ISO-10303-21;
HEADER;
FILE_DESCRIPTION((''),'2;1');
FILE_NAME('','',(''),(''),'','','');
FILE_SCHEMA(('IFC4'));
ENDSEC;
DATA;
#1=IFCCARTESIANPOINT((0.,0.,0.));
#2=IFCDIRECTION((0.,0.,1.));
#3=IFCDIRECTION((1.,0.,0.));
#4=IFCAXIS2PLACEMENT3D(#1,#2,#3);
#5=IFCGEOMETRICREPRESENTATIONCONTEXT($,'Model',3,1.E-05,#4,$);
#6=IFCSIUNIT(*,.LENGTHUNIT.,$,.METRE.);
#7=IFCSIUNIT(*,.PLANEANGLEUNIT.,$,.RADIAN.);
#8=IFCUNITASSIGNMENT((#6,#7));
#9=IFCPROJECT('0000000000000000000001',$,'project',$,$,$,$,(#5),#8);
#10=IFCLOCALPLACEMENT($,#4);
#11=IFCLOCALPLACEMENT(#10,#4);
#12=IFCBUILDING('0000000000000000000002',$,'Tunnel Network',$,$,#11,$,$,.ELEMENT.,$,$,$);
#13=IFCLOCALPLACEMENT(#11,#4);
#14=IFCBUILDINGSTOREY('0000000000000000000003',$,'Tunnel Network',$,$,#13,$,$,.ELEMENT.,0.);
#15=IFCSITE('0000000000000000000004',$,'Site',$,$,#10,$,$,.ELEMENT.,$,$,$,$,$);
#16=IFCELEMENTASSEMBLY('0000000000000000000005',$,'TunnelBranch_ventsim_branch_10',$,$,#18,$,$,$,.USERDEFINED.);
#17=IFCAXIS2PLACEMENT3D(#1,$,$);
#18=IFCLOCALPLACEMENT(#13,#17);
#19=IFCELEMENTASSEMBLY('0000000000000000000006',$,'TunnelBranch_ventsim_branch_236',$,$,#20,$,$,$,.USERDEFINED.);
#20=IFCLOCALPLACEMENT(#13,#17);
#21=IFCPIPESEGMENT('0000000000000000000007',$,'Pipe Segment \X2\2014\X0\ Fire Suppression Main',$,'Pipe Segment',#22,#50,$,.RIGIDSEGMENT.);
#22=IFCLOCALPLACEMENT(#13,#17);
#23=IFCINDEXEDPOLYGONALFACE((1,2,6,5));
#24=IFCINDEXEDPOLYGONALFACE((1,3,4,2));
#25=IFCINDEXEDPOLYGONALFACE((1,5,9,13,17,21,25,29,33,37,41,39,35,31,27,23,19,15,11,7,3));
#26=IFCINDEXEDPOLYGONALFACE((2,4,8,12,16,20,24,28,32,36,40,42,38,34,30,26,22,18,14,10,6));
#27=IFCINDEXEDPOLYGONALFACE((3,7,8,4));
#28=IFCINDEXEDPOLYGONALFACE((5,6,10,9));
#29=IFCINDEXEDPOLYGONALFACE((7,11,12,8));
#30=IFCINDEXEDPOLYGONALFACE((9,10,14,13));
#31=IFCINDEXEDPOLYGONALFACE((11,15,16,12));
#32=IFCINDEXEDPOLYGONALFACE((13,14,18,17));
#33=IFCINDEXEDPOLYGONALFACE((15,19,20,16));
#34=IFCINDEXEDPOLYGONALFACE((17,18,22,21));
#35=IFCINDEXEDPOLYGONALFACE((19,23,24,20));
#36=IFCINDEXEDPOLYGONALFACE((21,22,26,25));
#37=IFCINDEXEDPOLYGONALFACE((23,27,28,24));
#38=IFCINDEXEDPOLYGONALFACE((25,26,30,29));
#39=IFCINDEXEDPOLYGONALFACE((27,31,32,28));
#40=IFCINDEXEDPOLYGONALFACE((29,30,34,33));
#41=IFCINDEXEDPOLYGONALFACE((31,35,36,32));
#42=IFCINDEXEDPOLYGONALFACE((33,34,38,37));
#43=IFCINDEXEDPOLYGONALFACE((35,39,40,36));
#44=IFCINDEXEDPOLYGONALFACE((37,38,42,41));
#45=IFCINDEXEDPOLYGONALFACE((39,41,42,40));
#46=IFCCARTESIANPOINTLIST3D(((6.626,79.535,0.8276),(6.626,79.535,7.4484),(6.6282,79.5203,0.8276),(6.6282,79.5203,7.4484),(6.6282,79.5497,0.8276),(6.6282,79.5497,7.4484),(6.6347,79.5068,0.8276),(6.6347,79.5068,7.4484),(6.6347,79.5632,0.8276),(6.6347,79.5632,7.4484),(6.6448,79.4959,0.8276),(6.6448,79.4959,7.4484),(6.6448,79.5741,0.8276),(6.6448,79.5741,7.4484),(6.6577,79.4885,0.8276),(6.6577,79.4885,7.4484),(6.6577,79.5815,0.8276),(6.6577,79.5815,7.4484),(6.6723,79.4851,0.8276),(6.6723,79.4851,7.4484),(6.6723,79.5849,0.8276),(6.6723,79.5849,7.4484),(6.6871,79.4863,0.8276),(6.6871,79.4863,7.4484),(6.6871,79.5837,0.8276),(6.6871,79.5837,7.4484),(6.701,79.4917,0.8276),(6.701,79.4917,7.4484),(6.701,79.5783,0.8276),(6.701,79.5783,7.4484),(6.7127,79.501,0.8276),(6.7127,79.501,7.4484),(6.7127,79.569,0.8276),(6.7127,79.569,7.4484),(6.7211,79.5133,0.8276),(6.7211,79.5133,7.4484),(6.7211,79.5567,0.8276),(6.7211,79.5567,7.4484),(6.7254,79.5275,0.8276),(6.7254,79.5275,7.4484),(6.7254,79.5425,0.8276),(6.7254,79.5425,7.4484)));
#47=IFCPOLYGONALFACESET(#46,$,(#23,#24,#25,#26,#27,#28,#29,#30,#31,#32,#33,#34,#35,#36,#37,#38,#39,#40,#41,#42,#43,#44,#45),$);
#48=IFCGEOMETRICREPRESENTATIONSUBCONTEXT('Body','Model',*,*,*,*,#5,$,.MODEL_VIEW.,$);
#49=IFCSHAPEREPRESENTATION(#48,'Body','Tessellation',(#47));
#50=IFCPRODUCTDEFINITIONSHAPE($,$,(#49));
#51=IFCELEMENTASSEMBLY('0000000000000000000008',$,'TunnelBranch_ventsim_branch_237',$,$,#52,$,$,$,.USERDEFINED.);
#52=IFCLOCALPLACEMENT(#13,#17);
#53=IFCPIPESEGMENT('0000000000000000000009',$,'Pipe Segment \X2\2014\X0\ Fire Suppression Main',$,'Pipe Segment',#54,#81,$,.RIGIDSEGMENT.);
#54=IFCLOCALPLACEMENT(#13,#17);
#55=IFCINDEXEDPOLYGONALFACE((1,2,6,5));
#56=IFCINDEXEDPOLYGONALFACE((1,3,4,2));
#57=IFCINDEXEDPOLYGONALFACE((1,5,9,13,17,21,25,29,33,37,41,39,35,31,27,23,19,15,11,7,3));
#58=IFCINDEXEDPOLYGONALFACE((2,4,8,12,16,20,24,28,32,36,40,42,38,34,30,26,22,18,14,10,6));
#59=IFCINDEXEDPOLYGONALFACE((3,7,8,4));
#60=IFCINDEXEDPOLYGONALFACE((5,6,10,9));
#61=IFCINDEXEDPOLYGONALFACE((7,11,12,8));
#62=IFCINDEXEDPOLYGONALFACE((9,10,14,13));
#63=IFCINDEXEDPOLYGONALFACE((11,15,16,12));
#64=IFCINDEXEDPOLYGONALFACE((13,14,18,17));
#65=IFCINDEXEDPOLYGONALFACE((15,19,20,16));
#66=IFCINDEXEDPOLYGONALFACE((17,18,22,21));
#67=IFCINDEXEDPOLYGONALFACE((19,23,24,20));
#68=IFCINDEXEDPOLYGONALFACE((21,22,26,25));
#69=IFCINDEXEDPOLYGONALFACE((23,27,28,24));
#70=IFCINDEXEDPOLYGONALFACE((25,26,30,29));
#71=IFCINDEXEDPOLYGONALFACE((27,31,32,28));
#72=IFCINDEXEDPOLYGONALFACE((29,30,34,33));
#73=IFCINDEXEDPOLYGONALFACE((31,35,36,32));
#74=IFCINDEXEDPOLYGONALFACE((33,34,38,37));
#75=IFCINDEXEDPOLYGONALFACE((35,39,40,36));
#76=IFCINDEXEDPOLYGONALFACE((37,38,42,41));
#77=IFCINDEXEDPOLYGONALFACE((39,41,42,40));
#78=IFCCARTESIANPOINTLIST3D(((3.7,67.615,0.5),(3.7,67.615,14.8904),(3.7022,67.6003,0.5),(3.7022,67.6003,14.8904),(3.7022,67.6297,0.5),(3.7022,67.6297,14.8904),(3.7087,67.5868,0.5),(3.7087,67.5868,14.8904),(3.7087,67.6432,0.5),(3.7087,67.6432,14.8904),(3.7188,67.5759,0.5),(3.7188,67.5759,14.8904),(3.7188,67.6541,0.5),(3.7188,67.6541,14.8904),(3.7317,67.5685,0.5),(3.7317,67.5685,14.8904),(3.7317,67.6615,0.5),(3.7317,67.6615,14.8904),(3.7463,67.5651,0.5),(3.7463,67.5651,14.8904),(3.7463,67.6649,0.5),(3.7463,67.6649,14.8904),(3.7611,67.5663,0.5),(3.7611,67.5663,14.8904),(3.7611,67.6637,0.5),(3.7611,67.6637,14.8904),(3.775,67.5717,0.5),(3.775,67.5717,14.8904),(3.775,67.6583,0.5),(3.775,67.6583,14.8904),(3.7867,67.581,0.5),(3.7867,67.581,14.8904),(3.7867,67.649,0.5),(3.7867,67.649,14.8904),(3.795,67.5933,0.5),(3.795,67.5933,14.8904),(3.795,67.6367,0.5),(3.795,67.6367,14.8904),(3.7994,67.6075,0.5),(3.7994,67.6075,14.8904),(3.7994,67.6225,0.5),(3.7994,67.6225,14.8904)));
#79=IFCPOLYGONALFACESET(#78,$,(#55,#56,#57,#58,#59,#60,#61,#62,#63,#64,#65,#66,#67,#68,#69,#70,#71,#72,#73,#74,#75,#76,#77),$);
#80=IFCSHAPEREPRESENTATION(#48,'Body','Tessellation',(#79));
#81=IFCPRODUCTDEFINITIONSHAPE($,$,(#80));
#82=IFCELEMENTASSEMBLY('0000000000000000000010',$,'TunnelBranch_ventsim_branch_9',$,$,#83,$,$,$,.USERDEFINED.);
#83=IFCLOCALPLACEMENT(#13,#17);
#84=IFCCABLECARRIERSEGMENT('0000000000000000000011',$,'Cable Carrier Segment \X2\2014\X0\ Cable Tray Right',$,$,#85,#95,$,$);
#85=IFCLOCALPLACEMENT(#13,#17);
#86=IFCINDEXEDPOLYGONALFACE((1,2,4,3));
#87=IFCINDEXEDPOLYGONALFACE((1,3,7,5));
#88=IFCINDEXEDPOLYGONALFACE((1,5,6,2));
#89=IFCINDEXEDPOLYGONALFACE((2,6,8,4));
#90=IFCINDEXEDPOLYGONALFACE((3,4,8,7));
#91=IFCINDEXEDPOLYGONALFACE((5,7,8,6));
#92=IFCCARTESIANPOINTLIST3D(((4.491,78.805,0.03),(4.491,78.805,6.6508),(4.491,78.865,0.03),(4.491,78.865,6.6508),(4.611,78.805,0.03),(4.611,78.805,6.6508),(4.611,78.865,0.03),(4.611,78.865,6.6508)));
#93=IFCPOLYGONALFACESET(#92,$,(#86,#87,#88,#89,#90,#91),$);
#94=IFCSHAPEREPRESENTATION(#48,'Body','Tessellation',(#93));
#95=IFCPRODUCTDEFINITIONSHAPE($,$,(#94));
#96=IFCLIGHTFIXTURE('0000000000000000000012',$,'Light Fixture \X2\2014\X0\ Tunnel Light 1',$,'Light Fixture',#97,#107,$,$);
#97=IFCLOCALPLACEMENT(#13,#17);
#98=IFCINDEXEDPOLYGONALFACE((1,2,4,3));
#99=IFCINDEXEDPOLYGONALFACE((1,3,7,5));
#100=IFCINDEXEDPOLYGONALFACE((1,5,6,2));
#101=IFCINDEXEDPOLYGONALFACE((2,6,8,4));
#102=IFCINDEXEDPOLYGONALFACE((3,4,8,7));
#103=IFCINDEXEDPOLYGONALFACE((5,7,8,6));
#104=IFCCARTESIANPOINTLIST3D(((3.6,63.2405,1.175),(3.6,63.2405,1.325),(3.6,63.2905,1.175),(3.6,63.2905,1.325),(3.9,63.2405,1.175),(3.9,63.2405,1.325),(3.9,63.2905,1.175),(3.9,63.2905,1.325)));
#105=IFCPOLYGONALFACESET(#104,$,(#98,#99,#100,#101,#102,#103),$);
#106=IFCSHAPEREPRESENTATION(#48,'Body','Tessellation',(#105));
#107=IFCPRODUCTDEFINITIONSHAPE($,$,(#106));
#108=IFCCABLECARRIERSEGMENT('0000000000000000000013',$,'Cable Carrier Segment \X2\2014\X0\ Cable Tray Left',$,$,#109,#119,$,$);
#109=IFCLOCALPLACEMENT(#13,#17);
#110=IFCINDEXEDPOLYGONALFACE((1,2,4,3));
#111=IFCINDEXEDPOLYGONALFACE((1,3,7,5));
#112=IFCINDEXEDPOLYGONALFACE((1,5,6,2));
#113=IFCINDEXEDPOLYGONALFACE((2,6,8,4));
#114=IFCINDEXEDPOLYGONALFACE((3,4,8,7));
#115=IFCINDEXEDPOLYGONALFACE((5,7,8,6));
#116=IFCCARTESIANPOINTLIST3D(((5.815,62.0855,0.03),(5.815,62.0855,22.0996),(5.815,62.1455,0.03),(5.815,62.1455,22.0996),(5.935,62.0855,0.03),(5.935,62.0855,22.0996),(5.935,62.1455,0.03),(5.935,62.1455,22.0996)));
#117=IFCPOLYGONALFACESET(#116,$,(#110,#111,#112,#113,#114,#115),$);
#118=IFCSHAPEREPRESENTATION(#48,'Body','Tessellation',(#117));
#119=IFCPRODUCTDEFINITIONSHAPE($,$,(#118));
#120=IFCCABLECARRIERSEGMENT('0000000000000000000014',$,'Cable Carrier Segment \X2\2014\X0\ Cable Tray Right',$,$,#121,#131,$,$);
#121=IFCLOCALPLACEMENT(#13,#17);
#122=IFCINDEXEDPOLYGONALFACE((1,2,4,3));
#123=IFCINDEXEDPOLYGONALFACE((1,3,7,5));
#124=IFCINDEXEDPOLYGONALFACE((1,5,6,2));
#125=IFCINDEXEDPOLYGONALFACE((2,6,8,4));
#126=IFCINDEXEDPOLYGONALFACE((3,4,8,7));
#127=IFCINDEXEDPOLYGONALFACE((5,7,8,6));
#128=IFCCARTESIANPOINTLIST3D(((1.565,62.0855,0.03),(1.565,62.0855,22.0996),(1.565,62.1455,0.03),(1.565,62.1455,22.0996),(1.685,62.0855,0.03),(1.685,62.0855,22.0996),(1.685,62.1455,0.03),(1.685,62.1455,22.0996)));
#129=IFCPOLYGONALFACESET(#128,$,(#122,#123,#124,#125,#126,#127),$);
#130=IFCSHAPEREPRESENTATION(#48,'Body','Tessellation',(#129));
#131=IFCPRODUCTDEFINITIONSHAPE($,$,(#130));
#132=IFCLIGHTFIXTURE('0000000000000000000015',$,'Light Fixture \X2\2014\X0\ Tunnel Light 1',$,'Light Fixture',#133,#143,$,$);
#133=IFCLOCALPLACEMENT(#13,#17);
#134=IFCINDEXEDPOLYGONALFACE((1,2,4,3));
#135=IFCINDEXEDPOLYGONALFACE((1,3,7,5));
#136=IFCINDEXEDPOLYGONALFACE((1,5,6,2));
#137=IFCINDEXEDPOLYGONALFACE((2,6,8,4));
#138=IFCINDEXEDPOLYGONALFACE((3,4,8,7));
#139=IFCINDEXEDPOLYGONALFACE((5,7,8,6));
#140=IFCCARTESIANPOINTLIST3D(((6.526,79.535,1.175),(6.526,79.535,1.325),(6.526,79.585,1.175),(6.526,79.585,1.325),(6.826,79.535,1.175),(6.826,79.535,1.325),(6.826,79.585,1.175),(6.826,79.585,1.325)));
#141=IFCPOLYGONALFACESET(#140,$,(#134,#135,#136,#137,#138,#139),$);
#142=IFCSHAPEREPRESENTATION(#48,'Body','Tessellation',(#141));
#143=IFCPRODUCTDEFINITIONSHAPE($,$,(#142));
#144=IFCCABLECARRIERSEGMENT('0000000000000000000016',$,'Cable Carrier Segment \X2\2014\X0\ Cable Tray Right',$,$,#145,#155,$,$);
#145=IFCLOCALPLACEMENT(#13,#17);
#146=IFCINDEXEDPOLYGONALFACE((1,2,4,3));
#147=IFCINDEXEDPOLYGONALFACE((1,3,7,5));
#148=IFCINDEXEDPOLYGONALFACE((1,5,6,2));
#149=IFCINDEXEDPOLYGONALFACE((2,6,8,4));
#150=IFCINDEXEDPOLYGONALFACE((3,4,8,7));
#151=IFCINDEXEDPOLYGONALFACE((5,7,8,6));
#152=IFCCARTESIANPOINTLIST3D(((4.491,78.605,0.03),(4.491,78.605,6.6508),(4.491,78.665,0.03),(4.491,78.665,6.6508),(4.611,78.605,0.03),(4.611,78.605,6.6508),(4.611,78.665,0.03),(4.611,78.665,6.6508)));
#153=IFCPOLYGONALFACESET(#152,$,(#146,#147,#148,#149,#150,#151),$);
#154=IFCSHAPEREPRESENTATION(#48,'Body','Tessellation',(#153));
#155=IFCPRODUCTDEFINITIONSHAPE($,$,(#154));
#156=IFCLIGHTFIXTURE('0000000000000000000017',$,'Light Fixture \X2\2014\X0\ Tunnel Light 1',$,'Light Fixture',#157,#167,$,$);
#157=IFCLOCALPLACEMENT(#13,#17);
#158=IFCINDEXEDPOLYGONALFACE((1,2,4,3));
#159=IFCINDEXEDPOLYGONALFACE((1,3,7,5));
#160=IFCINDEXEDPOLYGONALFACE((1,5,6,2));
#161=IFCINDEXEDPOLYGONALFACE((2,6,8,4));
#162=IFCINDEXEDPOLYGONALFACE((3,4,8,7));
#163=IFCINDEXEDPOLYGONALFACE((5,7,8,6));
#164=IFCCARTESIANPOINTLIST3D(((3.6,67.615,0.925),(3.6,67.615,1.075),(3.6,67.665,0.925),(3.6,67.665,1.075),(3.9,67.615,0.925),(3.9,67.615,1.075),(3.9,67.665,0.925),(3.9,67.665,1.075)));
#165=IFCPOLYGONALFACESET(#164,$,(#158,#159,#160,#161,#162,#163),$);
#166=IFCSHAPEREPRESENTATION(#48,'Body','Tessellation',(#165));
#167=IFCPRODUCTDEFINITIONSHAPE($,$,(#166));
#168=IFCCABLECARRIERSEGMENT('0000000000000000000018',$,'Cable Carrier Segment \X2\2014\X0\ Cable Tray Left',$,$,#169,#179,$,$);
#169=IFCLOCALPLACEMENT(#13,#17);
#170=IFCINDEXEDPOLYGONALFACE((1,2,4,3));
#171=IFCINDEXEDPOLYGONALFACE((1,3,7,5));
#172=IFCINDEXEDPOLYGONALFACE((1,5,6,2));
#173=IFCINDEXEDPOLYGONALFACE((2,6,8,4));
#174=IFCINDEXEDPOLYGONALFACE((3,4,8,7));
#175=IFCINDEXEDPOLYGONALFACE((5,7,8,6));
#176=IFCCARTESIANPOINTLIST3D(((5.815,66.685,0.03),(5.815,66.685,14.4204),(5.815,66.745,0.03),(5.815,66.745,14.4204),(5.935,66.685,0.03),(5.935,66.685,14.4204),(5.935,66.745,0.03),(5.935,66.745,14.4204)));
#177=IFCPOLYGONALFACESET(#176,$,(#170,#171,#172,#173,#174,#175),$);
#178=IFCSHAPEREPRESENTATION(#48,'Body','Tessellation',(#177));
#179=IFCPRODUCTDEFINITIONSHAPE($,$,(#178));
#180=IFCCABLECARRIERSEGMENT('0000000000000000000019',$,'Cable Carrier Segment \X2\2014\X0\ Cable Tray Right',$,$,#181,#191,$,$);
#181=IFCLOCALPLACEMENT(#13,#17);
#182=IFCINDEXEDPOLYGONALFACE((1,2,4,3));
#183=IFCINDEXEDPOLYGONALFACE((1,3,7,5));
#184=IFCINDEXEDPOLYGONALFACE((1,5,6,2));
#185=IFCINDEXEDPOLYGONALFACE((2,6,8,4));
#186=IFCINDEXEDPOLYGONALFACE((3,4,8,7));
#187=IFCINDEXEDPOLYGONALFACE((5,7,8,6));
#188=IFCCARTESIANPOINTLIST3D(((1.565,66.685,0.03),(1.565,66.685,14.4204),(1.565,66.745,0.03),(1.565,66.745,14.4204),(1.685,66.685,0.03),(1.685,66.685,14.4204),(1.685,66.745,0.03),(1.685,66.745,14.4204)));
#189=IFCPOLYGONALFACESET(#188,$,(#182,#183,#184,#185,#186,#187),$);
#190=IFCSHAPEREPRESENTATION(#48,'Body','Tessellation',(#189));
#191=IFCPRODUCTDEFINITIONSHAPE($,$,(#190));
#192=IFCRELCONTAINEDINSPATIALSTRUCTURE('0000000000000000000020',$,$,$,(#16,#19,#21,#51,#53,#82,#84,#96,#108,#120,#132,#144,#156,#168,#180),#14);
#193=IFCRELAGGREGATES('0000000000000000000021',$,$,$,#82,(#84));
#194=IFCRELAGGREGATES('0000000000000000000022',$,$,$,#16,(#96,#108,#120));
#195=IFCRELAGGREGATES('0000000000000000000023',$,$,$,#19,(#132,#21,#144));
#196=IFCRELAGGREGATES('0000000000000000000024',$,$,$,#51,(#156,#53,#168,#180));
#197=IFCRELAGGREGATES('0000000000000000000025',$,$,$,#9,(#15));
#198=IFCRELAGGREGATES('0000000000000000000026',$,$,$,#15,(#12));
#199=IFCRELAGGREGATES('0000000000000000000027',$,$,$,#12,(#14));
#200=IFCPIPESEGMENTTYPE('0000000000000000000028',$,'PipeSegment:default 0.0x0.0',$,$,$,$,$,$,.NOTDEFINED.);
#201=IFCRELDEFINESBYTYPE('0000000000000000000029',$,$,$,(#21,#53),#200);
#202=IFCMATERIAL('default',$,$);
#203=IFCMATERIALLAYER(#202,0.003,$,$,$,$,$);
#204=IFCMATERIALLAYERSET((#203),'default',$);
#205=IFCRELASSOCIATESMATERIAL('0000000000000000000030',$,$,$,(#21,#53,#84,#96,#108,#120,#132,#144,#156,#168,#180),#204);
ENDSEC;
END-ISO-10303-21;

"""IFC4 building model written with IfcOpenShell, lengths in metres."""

from ifc_helpers import new_model, si_unit, frame, origin_with_axes, origin_2d_with_axis, place, context, subcontext, project, spatial, rectangle, circle, extrude, material, layer, layer_set, layer_usage, type_object, element, aggregate, save


model = new_model("IFC4")

# Units and contexts
model_context = context("Model", 3, precision=1e-05, world=origin_with_axes())
body_context = subcontext(model_context, "Body", "Model", "MODEL_VIEW")
ifc_project = project(units=[si_unit("LENGTHUNIT", "METRE"), si_unit("PLANEANGLEUNIT", "RADIAN")], contexts=[model_context])

# Site, building, storey
site_placement = place(None, origin_with_axes())
site = spatial("IfcSite", under=ifc_project, at=site_placement, Name="Site", CompositionType="ELEMENT")
building_placement = place(site_placement, origin_with_axes())
building = spatial("IfcBuilding", under=site, at=building_placement, Name="Tunnel Network", CompositionType="ELEMENT")
storey_placement = place(building_placement, origin_with_axes())
storey = spatial("IfcBuildingStorey", under=building, at=storey_placement, Name="Tunnel Network", CompositionType="ELEMENT", Elevation=0.0)

# Element assemblies, pipe segments
assembly_1_placement = place(storey_placement, frame((3.75, 63.2405, 1.25), z_axis=(0.0, 1.0, 0.0), x_axis=(-1.0, 0.0, 0.0)))
assembly_1 = element("IfcElementAssembly", 1, at=assembly_1_placement, inside=storey, Name="TunnelBranch_ventsim_branch_10", PredefinedType="USERDEFINED")
ifc_material_1 = material(Name="default")
ifc_layer_1 = layer(ifc_material_1, 0.003)
ifc_layer_set_1 = layer_set([ifc_layer_1], Name="default")
pipe_segment_type = type_object("IfcPipeSegmentType", Name="PipeSegment:default 0.0x0.0")
assembly_2_placement = place(storey_placement, frame((6.676, 79.535, 1.25), z_axis=(0.0, 1.0, 0.0), x_axis=(-1.0, 0.0, 0.0)))
assembly_2 = element("IfcElementAssembly", 2, at=assembly_2_placement, inside=storey, Name="TunnelBranch_ventsim_branch_236", PredefinedType="USERDEFINED")
ifc_layer_usage_1 = layer_usage(ifc_layer_set_1, "AXIS2", "POSITIVE", 0.0)
pipe_segment_1_placement = place(storey_placement, frame((6.676, 79.535, 0.8276), z_axis=(0.0, 0.0, 1.0), x_axis=(-1.0, 0.0, 0.0)))
pipe_segment_1 = element("IfcPipeSegment", 3, at=pipe_segment_1_placement, inside=storey, type_object=pipe_segment_type, material=ifc_layer_usage_1, Name="Pipe Segment — Fire Suppression Main", ObjectType="Pipe Segment", PredefinedType="RIGIDSEGMENT", context=body_context, shape_type="SweptSolid", body=[
    extrude(circle(Radius=0.05, at=origin_2d_with_axis()), origin_with_axes(), (0.0, 0.0, 1.0), 6.6208),
])
assembly_3_placement = place(storey_placement, frame((3.75, 67.615, 1.0), z_axis=(0.0, 1.0, 0.0), x_axis=(-1.0, 0.0, 0.0)))
assembly_3 = element("IfcElementAssembly", 4, at=assembly_3_placement, inside=storey, Name="TunnelBranch_ventsim_branch_237", PredefinedType="USERDEFINED")
ifc_layer_usage_2 = layer_usage(ifc_layer_set_1, "AXIS2", "POSITIVE", 0.0)
pipe_segment_2_placement = place(storey_placement, frame((3.75, 67.615, 0.5), z_axis=(0.0, 0.0, 1.0), x_axis=(-1.0, 0.0, 0.0)))
pipe_segment_2 = element("IfcPipeSegment", 5, at=pipe_segment_2_placement, inside=storey, type_object=pipe_segment_type, material=ifc_layer_usage_2, Name="Pipe Segment — Fire Suppression Main", ObjectType="Pipe Segment", PredefinedType="RIGIDSEGMENT", context=body_context, shape_type="SweptSolid", body=[
    extrude(circle(Radius=0.05, at=origin_2d_with_axis()), origin_with_axes(), (0.0, 0.0, 1.0), 14.3904),
])

# Element assembly, cable carrier segment
assembly_4_placement = place(storey_placement, frame((6.676, 79.96, 0.8276), z_axis=(0.0, 0.0, 1.0), x_axis=(-1.0, 0.0, 0.0)))
assembly_4 = element("IfcElementAssembly", 6, at=assembly_4_placement, inside=storey, Name="TunnelBranch_ventsim_branch_9", PredefinedType="USERDEFINED")
ifc_layer_usage_3 = layer_usage(ifc_layer_set_1, "AXIS2", "POSITIVE", 0.0)
cable_carrier_segment_1_placement = place(storey_placement, frame((4.551, 78.835, 0.03), z_axis=(0.0, 0.0, 1.0), x_axis=(-1.0, 0.0, 0.0)))
cable_carrier_segment_1 = element("IfcCableCarrierSegment", 7, at=cable_carrier_segment_1_placement, inside=storey, material=ifc_layer_usage_3, Name="Cable Carrier Segment — Cable Tray Right", context=body_context, shape_type="SweptSolid", body=[
    extrude(rectangle(XDim=0.12, YDim=0.06, at=origin_2d_with_axis()), origin_with_axes(), (0.0, 0.0, 1.0), 6.6208),
])
aggregate(assembly_4, [cable_carrier_segment_1])

# Light fixture
ifc_layer_usage_4 = layer_usage(ifc_layer_set_1, "AXIS2", "POSITIVE", 0.0)
light_fixture_1_placement = place(storey_placement, frame((3.75, 63.2405, 1.25), z_axis=(0.0, 1.0, 0.0), x_axis=(-1.0, 0.0, 0.0)))
light_fixture_1 = element("IfcLightFixture", 8, at=light_fixture_1_placement, inside=storey, material=ifc_layer_usage_4, Name="Light Fixture — Tunnel Light 1", ObjectType="Light Fixture", context=body_context, shape_type="SweptSolid", body=[
    extrude(rectangle(XDim=0.3, YDim=0.15, at=origin_2d_with_axis()), origin_with_axes(), (0.0, 0.0, 1.0), 0.05),
])

# Cable carrier segments
ifc_layer_usage_5 = layer_usage(ifc_layer_set_1, "AXIS2", "POSITIVE", 0.0)
cable_carrier_segment_2_placement = place(storey_placement, frame((5.875, 62.1155, 0.03), z_axis=(0.0, 0.0, 1.0), x_axis=(-1.0, 0.0, 0.0)))
cable_carrier_segment_2 = element("IfcCableCarrierSegment", 9, at=cable_carrier_segment_2_placement, inside=storey, material=ifc_layer_usage_5, Name="Cable Carrier Segment — Cable Tray Left", context=body_context, shape_type="SweptSolid", body=[
    extrude(rectangle(XDim=0.12, YDim=0.06, at=origin_2d_with_axis()), origin_with_axes(), (0.0, 0.0, 1.0), 22.0696),
])
ifc_layer_usage_6 = layer_usage(ifc_layer_set_1, "AXIS2", "POSITIVE", 0.0)
cable_carrier_segment_3_placement = place(storey_placement, frame((1.625, 62.1155, 0.03), z_axis=(0.0, 0.0, 1.0), x_axis=(-1.0, 0.0, 0.0)))
cable_carrier_segment_3 = element("IfcCableCarrierSegment", 10, at=cable_carrier_segment_3_placement, inside=storey, material=ifc_layer_usage_6, Name="Cable Carrier Segment — Cable Tray Right", context=body_context, shape_type="SweptSolid", body=[
    extrude(rectangle(XDim=0.12, YDim=0.06, at=origin_2d_with_axis()), origin_with_axes(), (0.0, 0.0, 1.0), 22.0696),
])
aggregate(assembly_1, [light_fixture_1, cable_carrier_segment_2, cable_carrier_segment_3])

# Light fixture
ifc_layer_usage_7 = layer_usage(ifc_layer_set_1, "AXIS2", "POSITIVE", 0.0)
light_fixture_2_placement = place(storey_placement, frame((6.676, 79.535, 1.25), z_axis=(0.0, 1.0, 0.0), x_axis=(-1.0, 0.0, 0.0)))
light_fixture_2 = element("IfcLightFixture", 11, at=light_fixture_2_placement, inside=storey, material=ifc_layer_usage_7, Name="Light Fixture — Tunnel Light 1", ObjectType="Light Fixture", context=body_context, shape_type="SweptSolid", body=[
    extrude(rectangle(XDim=0.3, YDim=0.15, at=origin_2d_with_axis()), origin_with_axes(), (0.0, 0.0, 1.0), 0.05),
])

# Cable carrier segment
ifc_layer_usage_8 = layer_usage(ifc_layer_set_1, "AXIS2", "POSITIVE", 0.0)
cable_carrier_segment_4_placement = place(storey_placement, frame((4.551, 78.635, 0.03), z_axis=(0.0, 0.0, 1.0), x_axis=(-1.0, 0.0, 0.0)))
cable_carrier_segment_4 = element("IfcCableCarrierSegment", 12, at=cable_carrier_segment_4_placement, inside=storey, material=ifc_layer_usage_8, Name="Cable Carrier Segment — Cable Tray Right", context=body_context, shape_type="SweptSolid", body=[
    extrude(rectangle(XDim=0.12, YDim=0.06, at=origin_2d_with_axis()), origin_with_axes(), (0.0, 0.0, 1.0), 6.6208),
])
aggregate(assembly_2, [light_fixture_2, pipe_segment_1, cable_carrier_segment_4])

# Light fixture
ifc_layer_usage_9 = layer_usage(ifc_layer_set_1, "AXIS2", "POSITIVE", 0.0)
light_fixture_3_placement = place(storey_placement, frame((3.75, 67.615, 1.0), z_axis=(0.0, 1.0, 0.0), x_axis=(-1.0, 0.0, 0.0)))
light_fixture_3 = element("IfcLightFixture", 13, at=light_fixture_3_placement, inside=storey, material=ifc_layer_usage_9, Name="Light Fixture — Tunnel Light 1", ObjectType="Light Fixture", context=body_context, shape_type="SweptSolid", body=[
    extrude(rectangle(XDim=0.3, YDim=0.15, at=origin_2d_with_axis()), origin_with_axes(), (0.0, 0.0, 1.0), 0.05),
])

# Cable carrier segments
ifc_layer_usage_10 = layer_usage(ifc_layer_set_1, "AXIS2", "POSITIVE", 0.0)
cable_carrier_segment_5_placement = place(storey_placement, frame((5.875, 66.715, 0.03), z_axis=(0.0, 0.0, 1.0), x_axis=(-1.0, 0.0, 0.0)))
cable_carrier_segment_5 = element("IfcCableCarrierSegment", 14, at=cable_carrier_segment_5_placement, inside=storey, material=ifc_layer_usage_10, Name="Cable Carrier Segment — Cable Tray Left", context=body_context, shape_type="SweptSolid", body=[
    extrude(rectangle(XDim=0.12, YDim=0.06, at=origin_2d_with_axis()), origin_with_axes(), (0.0, 0.0, 1.0), 14.3904),
])
ifc_layer_usage_11 = layer_usage(ifc_layer_set_1, "AXIS2", "POSITIVE", 0.0)
cable_carrier_segment_6_placement = place(storey_placement, frame((1.625, 66.715, 0.03), z_axis=(0.0, 0.0, 1.0), x_axis=(-1.0, 0.0, 0.0)))
cable_carrier_segment_6 = element("IfcCableCarrierSegment", 15, at=cable_carrier_segment_6_placement, inside=storey, material=ifc_layer_usage_11, Name="Cable Carrier Segment — Cable Tray Right", context=body_context, shape_type="SweptSolid", body=[
    extrude(rectangle(XDim=0.12, YDim=0.06, at=origin_2d_with_axis()), origin_with_axes(), (0.0, 0.0, 1.0), 14.3904),
])
aggregate(assembly_3, [light_fixture_3, pipe_segment_2, cable_carrier_segment_5, cable_carrier_segment_6])

save(model, "model.ifc")
